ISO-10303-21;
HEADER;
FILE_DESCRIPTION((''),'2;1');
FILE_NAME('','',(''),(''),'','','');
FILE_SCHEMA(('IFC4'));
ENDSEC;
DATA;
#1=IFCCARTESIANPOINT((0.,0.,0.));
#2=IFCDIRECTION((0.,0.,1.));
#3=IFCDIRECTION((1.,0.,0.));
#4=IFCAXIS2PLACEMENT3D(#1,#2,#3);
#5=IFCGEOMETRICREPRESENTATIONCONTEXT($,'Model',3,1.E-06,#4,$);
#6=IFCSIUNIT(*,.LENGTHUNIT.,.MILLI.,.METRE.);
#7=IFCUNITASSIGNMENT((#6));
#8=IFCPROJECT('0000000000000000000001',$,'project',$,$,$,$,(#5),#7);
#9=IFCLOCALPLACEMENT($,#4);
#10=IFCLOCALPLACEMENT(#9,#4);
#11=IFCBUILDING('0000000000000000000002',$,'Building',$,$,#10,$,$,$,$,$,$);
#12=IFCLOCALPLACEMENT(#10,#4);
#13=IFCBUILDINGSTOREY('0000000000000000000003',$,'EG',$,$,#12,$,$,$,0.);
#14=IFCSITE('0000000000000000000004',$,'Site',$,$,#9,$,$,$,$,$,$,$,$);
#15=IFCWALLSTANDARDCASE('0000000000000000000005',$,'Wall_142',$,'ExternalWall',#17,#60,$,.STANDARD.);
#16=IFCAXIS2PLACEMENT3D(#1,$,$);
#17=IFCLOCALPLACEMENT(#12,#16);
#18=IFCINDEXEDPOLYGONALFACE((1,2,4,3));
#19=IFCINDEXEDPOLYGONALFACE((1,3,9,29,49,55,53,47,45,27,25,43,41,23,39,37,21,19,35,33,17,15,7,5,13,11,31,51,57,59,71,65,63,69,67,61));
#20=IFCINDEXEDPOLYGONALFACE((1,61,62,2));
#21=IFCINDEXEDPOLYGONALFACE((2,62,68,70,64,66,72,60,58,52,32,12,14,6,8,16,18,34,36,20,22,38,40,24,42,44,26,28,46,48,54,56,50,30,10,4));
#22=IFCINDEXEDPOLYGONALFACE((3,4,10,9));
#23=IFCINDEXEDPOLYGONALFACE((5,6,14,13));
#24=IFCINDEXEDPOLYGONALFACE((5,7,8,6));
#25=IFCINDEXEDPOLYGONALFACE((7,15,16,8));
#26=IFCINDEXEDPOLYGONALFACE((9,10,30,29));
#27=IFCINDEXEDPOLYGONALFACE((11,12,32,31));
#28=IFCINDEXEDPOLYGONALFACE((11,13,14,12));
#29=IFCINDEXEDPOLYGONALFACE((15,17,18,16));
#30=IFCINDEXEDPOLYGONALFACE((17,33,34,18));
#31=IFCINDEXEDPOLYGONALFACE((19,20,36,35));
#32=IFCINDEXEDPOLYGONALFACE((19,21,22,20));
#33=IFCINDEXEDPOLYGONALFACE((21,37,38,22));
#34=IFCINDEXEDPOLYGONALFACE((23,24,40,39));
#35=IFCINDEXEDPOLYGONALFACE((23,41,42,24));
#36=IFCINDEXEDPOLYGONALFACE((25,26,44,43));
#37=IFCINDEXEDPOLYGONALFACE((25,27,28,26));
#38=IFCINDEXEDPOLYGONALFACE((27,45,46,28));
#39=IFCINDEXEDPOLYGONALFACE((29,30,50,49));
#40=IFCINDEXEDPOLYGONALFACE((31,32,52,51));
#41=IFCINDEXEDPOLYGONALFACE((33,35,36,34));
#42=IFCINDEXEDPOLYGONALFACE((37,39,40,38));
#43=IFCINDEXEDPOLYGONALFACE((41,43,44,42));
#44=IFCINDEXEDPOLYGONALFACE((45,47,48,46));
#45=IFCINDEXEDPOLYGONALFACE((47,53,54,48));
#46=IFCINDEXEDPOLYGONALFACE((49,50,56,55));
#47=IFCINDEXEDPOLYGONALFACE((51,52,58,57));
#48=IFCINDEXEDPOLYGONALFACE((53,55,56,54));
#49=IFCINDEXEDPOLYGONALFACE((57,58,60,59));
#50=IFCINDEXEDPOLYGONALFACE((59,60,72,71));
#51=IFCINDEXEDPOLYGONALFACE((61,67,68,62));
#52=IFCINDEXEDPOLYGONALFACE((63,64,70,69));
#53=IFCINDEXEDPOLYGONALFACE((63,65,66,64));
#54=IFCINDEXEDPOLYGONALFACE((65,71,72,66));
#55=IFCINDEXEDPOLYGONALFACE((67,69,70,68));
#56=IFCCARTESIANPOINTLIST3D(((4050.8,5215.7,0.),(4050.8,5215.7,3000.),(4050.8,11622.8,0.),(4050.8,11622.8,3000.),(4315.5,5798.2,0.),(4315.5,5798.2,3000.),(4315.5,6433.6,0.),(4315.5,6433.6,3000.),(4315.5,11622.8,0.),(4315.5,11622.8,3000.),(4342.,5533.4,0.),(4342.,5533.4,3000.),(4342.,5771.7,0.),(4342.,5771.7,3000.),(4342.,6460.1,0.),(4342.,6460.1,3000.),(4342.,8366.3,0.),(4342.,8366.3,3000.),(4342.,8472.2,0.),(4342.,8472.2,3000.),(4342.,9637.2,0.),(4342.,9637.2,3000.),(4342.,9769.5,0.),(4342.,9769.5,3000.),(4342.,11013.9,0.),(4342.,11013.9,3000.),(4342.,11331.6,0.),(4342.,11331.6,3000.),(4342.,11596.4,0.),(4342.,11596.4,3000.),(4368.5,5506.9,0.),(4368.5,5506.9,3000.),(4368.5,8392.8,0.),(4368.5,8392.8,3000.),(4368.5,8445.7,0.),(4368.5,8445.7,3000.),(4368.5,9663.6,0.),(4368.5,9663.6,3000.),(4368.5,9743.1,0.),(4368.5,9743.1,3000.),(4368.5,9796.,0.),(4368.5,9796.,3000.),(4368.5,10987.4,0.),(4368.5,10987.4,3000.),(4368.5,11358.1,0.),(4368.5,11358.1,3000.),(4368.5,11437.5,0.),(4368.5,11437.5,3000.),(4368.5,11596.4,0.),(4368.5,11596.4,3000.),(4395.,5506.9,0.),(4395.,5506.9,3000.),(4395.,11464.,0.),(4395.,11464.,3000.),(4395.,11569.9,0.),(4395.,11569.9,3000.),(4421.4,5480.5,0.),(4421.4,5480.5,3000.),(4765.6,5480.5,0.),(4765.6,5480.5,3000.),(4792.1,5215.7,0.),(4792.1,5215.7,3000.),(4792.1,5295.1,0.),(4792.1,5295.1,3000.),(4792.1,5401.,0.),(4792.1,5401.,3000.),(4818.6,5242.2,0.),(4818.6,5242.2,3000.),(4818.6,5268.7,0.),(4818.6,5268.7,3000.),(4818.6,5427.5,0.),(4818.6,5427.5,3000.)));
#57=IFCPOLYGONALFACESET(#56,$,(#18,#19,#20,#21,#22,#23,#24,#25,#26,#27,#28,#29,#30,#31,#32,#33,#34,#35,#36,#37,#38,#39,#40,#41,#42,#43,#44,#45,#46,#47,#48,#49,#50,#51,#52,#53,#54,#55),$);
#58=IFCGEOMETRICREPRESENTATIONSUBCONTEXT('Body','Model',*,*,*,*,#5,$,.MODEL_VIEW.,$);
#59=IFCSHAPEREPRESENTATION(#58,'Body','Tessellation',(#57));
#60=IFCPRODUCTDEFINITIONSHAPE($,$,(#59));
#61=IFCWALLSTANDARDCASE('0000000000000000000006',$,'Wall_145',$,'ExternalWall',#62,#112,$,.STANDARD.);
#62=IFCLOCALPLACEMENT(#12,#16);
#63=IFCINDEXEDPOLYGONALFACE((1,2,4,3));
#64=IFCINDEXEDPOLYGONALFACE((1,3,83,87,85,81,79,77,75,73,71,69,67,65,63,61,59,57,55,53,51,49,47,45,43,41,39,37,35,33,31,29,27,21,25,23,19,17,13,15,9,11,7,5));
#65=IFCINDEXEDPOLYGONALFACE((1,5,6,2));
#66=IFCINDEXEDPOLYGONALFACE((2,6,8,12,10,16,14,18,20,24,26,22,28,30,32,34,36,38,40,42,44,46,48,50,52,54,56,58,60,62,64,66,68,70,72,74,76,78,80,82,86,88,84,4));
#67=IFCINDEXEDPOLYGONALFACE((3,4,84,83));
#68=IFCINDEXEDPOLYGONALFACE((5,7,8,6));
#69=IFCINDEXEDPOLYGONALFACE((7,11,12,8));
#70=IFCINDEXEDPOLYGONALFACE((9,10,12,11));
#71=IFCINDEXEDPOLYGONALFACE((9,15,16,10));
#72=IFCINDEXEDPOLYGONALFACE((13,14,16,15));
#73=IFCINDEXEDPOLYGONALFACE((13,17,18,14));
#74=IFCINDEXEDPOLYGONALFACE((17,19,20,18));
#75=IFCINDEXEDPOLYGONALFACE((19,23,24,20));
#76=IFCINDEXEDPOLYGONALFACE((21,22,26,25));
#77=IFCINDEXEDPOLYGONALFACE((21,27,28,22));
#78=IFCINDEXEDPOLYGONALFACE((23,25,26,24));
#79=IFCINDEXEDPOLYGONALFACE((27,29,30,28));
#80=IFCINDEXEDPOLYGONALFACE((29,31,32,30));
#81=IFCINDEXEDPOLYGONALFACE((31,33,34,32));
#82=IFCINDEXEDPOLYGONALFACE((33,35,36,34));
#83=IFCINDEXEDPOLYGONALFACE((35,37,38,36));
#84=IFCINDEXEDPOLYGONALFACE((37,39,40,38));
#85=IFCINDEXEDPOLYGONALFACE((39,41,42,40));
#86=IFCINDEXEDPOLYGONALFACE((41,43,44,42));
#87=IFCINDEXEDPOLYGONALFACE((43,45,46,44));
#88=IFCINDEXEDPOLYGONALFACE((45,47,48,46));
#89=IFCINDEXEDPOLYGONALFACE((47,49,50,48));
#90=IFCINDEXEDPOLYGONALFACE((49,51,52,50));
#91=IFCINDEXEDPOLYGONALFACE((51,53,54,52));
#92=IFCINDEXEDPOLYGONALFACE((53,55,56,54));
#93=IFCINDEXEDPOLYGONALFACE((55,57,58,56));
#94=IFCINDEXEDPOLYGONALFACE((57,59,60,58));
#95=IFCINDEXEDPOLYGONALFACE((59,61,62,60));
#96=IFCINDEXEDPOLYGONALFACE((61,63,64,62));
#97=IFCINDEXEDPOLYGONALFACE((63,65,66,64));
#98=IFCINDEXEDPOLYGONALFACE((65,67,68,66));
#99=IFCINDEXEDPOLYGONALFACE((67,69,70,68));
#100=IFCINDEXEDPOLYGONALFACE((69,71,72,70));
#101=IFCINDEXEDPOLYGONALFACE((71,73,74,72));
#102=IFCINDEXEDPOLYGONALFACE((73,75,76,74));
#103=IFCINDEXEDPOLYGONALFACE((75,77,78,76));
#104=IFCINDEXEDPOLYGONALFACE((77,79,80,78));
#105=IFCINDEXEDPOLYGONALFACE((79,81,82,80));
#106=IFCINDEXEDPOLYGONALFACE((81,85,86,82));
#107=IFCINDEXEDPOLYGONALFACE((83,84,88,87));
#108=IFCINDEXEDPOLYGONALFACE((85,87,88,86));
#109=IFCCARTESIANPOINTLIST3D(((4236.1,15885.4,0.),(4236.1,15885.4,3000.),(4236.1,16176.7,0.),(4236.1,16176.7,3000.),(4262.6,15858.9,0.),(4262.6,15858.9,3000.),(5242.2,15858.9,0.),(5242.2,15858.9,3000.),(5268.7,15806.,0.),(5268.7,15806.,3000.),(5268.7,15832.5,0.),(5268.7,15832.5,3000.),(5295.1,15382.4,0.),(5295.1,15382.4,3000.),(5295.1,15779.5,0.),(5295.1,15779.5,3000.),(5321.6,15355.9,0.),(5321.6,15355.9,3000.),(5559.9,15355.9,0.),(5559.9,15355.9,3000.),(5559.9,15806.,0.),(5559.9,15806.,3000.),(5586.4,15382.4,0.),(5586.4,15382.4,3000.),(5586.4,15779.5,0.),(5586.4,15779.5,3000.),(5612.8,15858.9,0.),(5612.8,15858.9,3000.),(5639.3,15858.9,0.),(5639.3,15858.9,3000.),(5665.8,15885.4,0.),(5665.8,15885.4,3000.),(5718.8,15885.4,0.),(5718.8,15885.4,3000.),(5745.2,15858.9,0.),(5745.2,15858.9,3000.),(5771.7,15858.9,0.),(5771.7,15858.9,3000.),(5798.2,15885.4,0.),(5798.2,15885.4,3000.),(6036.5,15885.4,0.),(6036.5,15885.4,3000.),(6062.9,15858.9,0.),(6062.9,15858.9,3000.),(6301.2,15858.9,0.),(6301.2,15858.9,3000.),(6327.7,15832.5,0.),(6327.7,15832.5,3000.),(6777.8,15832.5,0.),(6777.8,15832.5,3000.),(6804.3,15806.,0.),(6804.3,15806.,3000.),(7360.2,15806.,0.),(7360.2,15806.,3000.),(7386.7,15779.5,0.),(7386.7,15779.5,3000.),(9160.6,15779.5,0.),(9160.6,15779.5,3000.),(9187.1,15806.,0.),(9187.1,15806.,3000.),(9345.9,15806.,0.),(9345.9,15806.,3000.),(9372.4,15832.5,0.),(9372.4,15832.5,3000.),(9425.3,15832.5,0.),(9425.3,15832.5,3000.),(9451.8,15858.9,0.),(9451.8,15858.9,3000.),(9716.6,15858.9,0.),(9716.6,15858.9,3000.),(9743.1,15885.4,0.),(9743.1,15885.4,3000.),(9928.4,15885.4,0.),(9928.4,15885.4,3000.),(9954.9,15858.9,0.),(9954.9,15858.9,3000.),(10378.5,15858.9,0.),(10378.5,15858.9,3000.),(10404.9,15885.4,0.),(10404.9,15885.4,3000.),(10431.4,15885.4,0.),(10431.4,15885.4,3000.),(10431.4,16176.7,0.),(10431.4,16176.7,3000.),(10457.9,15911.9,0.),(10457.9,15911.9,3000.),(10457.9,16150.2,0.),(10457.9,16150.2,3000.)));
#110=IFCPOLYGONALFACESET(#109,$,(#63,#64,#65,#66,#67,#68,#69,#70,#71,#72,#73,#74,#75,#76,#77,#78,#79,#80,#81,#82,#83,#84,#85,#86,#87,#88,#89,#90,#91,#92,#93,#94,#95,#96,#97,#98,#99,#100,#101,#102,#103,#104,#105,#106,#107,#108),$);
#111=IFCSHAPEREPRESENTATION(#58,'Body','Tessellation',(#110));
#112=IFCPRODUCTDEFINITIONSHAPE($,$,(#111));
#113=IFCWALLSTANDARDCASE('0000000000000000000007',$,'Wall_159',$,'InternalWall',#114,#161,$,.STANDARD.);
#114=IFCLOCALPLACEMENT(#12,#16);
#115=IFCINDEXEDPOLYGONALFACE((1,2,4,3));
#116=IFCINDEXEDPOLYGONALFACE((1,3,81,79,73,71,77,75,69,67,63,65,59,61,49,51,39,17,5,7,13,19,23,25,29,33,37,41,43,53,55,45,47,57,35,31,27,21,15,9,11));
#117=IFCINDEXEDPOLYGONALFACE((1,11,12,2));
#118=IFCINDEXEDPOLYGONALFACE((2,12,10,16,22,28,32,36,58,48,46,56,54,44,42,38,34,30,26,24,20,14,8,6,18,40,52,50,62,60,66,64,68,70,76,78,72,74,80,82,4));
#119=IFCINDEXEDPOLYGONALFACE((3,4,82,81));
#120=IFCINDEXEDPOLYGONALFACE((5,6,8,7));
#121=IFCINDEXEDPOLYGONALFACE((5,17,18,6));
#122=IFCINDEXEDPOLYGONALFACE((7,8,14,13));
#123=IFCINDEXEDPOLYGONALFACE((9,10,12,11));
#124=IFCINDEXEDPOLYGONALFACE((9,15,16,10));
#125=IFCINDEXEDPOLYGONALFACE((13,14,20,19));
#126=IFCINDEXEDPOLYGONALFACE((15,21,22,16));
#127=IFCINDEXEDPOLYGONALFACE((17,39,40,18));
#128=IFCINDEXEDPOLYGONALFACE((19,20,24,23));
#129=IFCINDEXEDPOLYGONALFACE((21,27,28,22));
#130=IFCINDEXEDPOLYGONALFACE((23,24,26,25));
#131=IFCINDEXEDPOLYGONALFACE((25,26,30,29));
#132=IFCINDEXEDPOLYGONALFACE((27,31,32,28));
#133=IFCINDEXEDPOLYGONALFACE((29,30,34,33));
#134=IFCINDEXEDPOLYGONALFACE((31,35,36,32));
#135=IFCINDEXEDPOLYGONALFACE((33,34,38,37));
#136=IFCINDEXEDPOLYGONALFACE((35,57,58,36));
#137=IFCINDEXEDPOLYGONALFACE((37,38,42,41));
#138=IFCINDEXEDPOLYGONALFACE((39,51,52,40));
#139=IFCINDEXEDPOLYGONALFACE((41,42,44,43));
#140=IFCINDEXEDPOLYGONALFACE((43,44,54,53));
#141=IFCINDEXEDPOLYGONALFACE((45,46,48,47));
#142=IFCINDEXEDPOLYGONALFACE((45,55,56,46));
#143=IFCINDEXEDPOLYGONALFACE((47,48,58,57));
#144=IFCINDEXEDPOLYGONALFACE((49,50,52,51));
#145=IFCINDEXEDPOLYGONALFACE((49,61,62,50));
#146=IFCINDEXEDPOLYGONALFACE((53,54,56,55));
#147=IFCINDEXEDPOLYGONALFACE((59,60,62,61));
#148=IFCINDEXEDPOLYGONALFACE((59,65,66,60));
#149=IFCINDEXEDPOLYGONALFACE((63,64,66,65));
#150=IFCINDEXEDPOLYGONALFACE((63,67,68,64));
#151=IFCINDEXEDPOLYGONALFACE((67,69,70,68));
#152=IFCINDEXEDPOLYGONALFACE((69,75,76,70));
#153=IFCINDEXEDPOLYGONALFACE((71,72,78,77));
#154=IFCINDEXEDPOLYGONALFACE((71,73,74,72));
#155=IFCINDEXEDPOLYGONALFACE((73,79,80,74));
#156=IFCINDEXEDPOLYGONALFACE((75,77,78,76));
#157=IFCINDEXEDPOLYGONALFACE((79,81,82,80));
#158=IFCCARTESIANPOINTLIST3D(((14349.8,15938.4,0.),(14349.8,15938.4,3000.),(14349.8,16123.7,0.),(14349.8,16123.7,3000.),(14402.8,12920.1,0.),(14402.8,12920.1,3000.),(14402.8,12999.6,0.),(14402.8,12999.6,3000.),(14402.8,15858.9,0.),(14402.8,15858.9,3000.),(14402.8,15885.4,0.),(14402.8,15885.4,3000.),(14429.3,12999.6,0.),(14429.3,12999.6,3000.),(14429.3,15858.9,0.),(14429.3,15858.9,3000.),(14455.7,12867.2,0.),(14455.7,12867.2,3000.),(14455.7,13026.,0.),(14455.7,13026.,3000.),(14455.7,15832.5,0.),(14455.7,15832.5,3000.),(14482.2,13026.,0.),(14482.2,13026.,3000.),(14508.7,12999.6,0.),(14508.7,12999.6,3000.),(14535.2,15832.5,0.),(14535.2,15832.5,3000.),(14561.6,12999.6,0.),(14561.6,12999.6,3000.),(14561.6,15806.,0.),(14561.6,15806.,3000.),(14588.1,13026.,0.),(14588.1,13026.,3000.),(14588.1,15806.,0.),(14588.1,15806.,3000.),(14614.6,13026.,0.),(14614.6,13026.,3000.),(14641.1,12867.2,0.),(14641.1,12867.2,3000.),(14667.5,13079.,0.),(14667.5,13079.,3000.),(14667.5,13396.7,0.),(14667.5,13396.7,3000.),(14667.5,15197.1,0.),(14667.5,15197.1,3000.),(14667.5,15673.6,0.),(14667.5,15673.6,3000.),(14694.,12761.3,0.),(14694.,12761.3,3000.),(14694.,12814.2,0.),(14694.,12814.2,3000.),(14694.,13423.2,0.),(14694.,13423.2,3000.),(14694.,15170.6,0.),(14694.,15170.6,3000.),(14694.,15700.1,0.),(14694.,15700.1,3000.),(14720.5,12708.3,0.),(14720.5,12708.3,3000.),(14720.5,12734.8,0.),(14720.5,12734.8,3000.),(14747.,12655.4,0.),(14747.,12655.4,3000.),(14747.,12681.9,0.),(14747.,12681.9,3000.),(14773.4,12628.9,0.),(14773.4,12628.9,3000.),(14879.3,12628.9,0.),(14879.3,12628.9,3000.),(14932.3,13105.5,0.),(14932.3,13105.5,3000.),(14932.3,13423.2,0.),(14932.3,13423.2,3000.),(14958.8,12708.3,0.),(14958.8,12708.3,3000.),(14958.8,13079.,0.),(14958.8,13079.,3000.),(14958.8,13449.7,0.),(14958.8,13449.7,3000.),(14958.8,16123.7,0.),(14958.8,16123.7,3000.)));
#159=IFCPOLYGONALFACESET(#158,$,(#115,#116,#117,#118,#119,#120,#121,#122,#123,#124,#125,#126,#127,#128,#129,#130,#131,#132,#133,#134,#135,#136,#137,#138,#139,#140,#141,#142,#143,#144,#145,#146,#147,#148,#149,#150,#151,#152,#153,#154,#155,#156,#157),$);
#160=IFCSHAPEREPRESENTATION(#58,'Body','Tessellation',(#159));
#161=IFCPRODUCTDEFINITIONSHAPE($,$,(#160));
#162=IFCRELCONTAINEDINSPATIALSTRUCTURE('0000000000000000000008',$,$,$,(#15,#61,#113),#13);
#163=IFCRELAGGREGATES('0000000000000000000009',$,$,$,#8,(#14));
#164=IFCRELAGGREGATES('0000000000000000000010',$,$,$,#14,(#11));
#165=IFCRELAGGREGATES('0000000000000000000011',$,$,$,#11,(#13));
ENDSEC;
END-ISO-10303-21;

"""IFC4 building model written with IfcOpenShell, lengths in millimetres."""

from ifc_helpers import new_model, si_unit, origin_with_axes, place, context, subcontext, project, spatial, polyline, outline, extrude, element, save


model = new_model("IFC4")

# Units and contexts
model_context = context("Model", 3, precision=1e-06, world=origin_with_axes())
body_context = subcontext(model_context, "Body", "Model", "MODEL_VIEW")
ifc_project = project(units=[si_unit("LENGTHUNIT", "METRE", prefix="MILLI")], contexts=[model_context])

# Site, building, storey
site_placement = place(None, origin_with_axes())
site = spatial("IfcSite", under=ifc_project, at=site_placement, Name="Site")
building_placement = place(site_placement, origin_with_axes())
building = spatial("IfcBuilding", under=site, at=building_placement, Name="Building")
storey_placement = place(building_placement, origin_with_axes())
storey = spatial("IfcBuildingStorey", under=building, at=storey_placement, Name="EG", Elevation=0.0)

# Wall
wall_1_placement = place(storey_placement, origin_with_axes())
element("IfcWallStandardCase", 1, at=wall_1_placement, inside=storey, Name="Wall_142", ObjectType="ExternalWall", PredefinedType="STANDARD", context=body_context, shape_type="SweptSolid", body=[
    extrude(outline(polyline([(4050.8, 5215.7, 0.0), (4050.8, 11622.8, 0.0), (4315.5, 11622.8, 0.0), (4342.0, 11596.4, 0.0), (4368.5, 11596.4, 0.0), (4395.0, 11569.9, 0.0), (4395.0, 11464.0, 0.0), (4368.5, 11437.5, 0.0), (4368.5, 11358.1, 0.0), (4342.0, 11331.6, 0.0), (4342.0, 11013.9, 0.0), (4368.5, 10987.4, 0.0), (4368.5, 9796.0, 0.0), (4342.0, 9769.5, 0.0), (4368.5, 9743.1, 0.0), (4368.5, 9663.6, 0.0), (4342.0, 9637.2, 0.0), (4342.0, 8472.2, 0.0), (4368.5, 8445.7, 0.0), (4368.5, 8392.8, 0.0), (4342.0, 8366.3, 0.0), (4342.0, 6460.1, 0.0), (4315.5, 6433.6, 0.0), (4315.5, 5798.2, 0.0), (4342.0, 5771.7, 0.0), (4342.0, 5533.4, 0.0), (4368.5, 5506.9, 0.0), (4395.0, 5506.9, 0.0), (4421.4, 5480.5, 0.0), (4765.6, 5480.5, 0.0), (4818.6, 5427.5, 0.0), (4792.1, 5401.0, 0.0), (4792.1, 5295.1, 0.0), (4818.6, 5268.7, 0.0), (4818.6, 5242.2, 0.0), (4792.1, 5215.7, 0.0), (4050.8, 5215.7, 0.0)])), origin_with_axes(), (0.0, 0.0, 1.0), 3000.0),
])

# Walls
wall_2_placement = place(storey_placement, origin_with_axes())
element("IfcWallStandardCase", 2, at=wall_2_placement, inside=storey, Name="Wall_145", ObjectType="ExternalWall", PredefinedType="STANDARD", context=body_context, shape_type="SweptSolid", body=[
    extrude(outline(polyline([(5321.6, 15355.9, 0.0), (5295.1, 15382.4, 0.0), (5295.1, 15779.5, 0.0), (5268.7, 15806.0, 0.0), (5268.7, 15832.5, 0.0), (5242.2, 15858.9, 0.0), (4262.6, 15858.9, 0.0), (4236.1, 15885.4, 0.0), (4236.1, 16176.7, 0.0), (10431.4, 16176.7, 0.0), (10457.9, 16150.2, 0.0), (10457.9, 15911.9, 0.0), (10431.4, 15885.4, 0.0), (10404.9, 15885.4, 0.0), (10378.5, 15858.9, 0.0), (9954.9, 15858.9, 0.0), (9928.4, 15885.4, 0.0), (9743.1, 15885.4, 0.0), (9716.6, 15858.9, 0.0), (9451.8, 15858.9, 0.0), (9425.3, 15832.5, 0.0), (9372.4, 15832.5, 0.0), (9345.9, 15806.0, 0.0), (9187.1, 15806.0, 0.0), (9160.6, 15779.5, 0.0), (7386.7, 15779.5, 0.0), (7360.2, 15806.0, 0.0), (6804.3, 15806.0, 0.0), (6777.8, 15832.5, 0.0), (6327.7, 15832.5, 0.0), (6301.2, 15858.9, 0.0), (6062.9, 15858.9, 0.0), (6036.5, 15885.4, 0.0), (5798.2, 15885.4, 0.0), (5771.7, 15858.9, 0.0), (5745.2, 15858.9, 0.0), (5718.8, 15885.4, 0.0), (5665.8, 15885.4, 0.0), (5639.3, 15858.9, 0.0), (5612.8, 15858.9, 0.0), (5559.9, 15806.0, 0.0), (5586.4, 15779.5, 0.0), (5586.4, 15382.4, 0.0), (5559.9, 15355.9, 0.0), (5321.6, 15355.9, 0.0)])), origin_with_axes(), (0.0, 0.0, 1.0), 3000.0),
])
wall_3_placement = place(storey_placement, origin_with_axes())
element("IfcWallStandardCase", 3, at=wall_3_placement, inside=storey, Name="Wall_159", ObjectType="InternalWall", PredefinedType="STANDARD", context=body_context, shape_type="SweptSolid", body=[
    extrude(outline(polyline([(14773.4, 12628.9, 0.0), (14747.0, 12655.4, 0.0), (14747.0, 12681.9, 0.0), (14720.5, 12708.3, 0.0), (14720.5, 12734.8, 0.0), (14694.0, 12761.3, 0.0), (14694.0, 12814.2, 0.0), (14641.1, 12867.2, 0.0), (14455.7, 12867.2, 0.0), (14402.8, 12920.1, 0.0), (14402.8, 12999.6, 0.0), (14429.3, 12999.6, 0.0), (14455.7, 13026.0, 0.0), (14482.2, 13026.0, 0.0), (14508.7, 12999.6, 0.0), (14561.6, 12999.6, 0.0), (14588.1, 13026.0, 0.0), (14614.6, 13026.0, 0.0), (14667.5, 13079.0, 0.0), (14667.5, 13396.7, 0.0), (14694.0, 13423.2, 0.0), (14694.0, 15170.6, 0.0), (14667.5, 15197.1, 0.0), (14667.5, 15673.6, 0.0), (14694.0, 15700.1, 0.0), (14588.1, 15806.0, 0.0), (14561.6, 15806.0, 0.0), (14535.2, 15832.5, 0.0), (14455.7, 15832.5, 0.0), (14429.3, 15858.9, 0.0), (14402.8, 15858.9, 0.0), (14402.8, 15885.4, 0.0), (14349.8, 15938.4, 0.0), (14349.8, 16123.7, 0.0), (14958.8, 16123.7, 0.0), (14958.8, 13449.7, 0.0), (14932.3, 13423.2, 0.0), (14932.3, 13105.5, 0.0), (14958.8, 13079.0, 0.0), (14958.8, 12708.3, 0.0), (14879.3, 12628.9, 0.0), (14773.4, 12628.9, 0.0)])), origin_with_axes(), (0.0, 0.0, 1.0), 3000.0),
])

save(model, "model.ifc")
